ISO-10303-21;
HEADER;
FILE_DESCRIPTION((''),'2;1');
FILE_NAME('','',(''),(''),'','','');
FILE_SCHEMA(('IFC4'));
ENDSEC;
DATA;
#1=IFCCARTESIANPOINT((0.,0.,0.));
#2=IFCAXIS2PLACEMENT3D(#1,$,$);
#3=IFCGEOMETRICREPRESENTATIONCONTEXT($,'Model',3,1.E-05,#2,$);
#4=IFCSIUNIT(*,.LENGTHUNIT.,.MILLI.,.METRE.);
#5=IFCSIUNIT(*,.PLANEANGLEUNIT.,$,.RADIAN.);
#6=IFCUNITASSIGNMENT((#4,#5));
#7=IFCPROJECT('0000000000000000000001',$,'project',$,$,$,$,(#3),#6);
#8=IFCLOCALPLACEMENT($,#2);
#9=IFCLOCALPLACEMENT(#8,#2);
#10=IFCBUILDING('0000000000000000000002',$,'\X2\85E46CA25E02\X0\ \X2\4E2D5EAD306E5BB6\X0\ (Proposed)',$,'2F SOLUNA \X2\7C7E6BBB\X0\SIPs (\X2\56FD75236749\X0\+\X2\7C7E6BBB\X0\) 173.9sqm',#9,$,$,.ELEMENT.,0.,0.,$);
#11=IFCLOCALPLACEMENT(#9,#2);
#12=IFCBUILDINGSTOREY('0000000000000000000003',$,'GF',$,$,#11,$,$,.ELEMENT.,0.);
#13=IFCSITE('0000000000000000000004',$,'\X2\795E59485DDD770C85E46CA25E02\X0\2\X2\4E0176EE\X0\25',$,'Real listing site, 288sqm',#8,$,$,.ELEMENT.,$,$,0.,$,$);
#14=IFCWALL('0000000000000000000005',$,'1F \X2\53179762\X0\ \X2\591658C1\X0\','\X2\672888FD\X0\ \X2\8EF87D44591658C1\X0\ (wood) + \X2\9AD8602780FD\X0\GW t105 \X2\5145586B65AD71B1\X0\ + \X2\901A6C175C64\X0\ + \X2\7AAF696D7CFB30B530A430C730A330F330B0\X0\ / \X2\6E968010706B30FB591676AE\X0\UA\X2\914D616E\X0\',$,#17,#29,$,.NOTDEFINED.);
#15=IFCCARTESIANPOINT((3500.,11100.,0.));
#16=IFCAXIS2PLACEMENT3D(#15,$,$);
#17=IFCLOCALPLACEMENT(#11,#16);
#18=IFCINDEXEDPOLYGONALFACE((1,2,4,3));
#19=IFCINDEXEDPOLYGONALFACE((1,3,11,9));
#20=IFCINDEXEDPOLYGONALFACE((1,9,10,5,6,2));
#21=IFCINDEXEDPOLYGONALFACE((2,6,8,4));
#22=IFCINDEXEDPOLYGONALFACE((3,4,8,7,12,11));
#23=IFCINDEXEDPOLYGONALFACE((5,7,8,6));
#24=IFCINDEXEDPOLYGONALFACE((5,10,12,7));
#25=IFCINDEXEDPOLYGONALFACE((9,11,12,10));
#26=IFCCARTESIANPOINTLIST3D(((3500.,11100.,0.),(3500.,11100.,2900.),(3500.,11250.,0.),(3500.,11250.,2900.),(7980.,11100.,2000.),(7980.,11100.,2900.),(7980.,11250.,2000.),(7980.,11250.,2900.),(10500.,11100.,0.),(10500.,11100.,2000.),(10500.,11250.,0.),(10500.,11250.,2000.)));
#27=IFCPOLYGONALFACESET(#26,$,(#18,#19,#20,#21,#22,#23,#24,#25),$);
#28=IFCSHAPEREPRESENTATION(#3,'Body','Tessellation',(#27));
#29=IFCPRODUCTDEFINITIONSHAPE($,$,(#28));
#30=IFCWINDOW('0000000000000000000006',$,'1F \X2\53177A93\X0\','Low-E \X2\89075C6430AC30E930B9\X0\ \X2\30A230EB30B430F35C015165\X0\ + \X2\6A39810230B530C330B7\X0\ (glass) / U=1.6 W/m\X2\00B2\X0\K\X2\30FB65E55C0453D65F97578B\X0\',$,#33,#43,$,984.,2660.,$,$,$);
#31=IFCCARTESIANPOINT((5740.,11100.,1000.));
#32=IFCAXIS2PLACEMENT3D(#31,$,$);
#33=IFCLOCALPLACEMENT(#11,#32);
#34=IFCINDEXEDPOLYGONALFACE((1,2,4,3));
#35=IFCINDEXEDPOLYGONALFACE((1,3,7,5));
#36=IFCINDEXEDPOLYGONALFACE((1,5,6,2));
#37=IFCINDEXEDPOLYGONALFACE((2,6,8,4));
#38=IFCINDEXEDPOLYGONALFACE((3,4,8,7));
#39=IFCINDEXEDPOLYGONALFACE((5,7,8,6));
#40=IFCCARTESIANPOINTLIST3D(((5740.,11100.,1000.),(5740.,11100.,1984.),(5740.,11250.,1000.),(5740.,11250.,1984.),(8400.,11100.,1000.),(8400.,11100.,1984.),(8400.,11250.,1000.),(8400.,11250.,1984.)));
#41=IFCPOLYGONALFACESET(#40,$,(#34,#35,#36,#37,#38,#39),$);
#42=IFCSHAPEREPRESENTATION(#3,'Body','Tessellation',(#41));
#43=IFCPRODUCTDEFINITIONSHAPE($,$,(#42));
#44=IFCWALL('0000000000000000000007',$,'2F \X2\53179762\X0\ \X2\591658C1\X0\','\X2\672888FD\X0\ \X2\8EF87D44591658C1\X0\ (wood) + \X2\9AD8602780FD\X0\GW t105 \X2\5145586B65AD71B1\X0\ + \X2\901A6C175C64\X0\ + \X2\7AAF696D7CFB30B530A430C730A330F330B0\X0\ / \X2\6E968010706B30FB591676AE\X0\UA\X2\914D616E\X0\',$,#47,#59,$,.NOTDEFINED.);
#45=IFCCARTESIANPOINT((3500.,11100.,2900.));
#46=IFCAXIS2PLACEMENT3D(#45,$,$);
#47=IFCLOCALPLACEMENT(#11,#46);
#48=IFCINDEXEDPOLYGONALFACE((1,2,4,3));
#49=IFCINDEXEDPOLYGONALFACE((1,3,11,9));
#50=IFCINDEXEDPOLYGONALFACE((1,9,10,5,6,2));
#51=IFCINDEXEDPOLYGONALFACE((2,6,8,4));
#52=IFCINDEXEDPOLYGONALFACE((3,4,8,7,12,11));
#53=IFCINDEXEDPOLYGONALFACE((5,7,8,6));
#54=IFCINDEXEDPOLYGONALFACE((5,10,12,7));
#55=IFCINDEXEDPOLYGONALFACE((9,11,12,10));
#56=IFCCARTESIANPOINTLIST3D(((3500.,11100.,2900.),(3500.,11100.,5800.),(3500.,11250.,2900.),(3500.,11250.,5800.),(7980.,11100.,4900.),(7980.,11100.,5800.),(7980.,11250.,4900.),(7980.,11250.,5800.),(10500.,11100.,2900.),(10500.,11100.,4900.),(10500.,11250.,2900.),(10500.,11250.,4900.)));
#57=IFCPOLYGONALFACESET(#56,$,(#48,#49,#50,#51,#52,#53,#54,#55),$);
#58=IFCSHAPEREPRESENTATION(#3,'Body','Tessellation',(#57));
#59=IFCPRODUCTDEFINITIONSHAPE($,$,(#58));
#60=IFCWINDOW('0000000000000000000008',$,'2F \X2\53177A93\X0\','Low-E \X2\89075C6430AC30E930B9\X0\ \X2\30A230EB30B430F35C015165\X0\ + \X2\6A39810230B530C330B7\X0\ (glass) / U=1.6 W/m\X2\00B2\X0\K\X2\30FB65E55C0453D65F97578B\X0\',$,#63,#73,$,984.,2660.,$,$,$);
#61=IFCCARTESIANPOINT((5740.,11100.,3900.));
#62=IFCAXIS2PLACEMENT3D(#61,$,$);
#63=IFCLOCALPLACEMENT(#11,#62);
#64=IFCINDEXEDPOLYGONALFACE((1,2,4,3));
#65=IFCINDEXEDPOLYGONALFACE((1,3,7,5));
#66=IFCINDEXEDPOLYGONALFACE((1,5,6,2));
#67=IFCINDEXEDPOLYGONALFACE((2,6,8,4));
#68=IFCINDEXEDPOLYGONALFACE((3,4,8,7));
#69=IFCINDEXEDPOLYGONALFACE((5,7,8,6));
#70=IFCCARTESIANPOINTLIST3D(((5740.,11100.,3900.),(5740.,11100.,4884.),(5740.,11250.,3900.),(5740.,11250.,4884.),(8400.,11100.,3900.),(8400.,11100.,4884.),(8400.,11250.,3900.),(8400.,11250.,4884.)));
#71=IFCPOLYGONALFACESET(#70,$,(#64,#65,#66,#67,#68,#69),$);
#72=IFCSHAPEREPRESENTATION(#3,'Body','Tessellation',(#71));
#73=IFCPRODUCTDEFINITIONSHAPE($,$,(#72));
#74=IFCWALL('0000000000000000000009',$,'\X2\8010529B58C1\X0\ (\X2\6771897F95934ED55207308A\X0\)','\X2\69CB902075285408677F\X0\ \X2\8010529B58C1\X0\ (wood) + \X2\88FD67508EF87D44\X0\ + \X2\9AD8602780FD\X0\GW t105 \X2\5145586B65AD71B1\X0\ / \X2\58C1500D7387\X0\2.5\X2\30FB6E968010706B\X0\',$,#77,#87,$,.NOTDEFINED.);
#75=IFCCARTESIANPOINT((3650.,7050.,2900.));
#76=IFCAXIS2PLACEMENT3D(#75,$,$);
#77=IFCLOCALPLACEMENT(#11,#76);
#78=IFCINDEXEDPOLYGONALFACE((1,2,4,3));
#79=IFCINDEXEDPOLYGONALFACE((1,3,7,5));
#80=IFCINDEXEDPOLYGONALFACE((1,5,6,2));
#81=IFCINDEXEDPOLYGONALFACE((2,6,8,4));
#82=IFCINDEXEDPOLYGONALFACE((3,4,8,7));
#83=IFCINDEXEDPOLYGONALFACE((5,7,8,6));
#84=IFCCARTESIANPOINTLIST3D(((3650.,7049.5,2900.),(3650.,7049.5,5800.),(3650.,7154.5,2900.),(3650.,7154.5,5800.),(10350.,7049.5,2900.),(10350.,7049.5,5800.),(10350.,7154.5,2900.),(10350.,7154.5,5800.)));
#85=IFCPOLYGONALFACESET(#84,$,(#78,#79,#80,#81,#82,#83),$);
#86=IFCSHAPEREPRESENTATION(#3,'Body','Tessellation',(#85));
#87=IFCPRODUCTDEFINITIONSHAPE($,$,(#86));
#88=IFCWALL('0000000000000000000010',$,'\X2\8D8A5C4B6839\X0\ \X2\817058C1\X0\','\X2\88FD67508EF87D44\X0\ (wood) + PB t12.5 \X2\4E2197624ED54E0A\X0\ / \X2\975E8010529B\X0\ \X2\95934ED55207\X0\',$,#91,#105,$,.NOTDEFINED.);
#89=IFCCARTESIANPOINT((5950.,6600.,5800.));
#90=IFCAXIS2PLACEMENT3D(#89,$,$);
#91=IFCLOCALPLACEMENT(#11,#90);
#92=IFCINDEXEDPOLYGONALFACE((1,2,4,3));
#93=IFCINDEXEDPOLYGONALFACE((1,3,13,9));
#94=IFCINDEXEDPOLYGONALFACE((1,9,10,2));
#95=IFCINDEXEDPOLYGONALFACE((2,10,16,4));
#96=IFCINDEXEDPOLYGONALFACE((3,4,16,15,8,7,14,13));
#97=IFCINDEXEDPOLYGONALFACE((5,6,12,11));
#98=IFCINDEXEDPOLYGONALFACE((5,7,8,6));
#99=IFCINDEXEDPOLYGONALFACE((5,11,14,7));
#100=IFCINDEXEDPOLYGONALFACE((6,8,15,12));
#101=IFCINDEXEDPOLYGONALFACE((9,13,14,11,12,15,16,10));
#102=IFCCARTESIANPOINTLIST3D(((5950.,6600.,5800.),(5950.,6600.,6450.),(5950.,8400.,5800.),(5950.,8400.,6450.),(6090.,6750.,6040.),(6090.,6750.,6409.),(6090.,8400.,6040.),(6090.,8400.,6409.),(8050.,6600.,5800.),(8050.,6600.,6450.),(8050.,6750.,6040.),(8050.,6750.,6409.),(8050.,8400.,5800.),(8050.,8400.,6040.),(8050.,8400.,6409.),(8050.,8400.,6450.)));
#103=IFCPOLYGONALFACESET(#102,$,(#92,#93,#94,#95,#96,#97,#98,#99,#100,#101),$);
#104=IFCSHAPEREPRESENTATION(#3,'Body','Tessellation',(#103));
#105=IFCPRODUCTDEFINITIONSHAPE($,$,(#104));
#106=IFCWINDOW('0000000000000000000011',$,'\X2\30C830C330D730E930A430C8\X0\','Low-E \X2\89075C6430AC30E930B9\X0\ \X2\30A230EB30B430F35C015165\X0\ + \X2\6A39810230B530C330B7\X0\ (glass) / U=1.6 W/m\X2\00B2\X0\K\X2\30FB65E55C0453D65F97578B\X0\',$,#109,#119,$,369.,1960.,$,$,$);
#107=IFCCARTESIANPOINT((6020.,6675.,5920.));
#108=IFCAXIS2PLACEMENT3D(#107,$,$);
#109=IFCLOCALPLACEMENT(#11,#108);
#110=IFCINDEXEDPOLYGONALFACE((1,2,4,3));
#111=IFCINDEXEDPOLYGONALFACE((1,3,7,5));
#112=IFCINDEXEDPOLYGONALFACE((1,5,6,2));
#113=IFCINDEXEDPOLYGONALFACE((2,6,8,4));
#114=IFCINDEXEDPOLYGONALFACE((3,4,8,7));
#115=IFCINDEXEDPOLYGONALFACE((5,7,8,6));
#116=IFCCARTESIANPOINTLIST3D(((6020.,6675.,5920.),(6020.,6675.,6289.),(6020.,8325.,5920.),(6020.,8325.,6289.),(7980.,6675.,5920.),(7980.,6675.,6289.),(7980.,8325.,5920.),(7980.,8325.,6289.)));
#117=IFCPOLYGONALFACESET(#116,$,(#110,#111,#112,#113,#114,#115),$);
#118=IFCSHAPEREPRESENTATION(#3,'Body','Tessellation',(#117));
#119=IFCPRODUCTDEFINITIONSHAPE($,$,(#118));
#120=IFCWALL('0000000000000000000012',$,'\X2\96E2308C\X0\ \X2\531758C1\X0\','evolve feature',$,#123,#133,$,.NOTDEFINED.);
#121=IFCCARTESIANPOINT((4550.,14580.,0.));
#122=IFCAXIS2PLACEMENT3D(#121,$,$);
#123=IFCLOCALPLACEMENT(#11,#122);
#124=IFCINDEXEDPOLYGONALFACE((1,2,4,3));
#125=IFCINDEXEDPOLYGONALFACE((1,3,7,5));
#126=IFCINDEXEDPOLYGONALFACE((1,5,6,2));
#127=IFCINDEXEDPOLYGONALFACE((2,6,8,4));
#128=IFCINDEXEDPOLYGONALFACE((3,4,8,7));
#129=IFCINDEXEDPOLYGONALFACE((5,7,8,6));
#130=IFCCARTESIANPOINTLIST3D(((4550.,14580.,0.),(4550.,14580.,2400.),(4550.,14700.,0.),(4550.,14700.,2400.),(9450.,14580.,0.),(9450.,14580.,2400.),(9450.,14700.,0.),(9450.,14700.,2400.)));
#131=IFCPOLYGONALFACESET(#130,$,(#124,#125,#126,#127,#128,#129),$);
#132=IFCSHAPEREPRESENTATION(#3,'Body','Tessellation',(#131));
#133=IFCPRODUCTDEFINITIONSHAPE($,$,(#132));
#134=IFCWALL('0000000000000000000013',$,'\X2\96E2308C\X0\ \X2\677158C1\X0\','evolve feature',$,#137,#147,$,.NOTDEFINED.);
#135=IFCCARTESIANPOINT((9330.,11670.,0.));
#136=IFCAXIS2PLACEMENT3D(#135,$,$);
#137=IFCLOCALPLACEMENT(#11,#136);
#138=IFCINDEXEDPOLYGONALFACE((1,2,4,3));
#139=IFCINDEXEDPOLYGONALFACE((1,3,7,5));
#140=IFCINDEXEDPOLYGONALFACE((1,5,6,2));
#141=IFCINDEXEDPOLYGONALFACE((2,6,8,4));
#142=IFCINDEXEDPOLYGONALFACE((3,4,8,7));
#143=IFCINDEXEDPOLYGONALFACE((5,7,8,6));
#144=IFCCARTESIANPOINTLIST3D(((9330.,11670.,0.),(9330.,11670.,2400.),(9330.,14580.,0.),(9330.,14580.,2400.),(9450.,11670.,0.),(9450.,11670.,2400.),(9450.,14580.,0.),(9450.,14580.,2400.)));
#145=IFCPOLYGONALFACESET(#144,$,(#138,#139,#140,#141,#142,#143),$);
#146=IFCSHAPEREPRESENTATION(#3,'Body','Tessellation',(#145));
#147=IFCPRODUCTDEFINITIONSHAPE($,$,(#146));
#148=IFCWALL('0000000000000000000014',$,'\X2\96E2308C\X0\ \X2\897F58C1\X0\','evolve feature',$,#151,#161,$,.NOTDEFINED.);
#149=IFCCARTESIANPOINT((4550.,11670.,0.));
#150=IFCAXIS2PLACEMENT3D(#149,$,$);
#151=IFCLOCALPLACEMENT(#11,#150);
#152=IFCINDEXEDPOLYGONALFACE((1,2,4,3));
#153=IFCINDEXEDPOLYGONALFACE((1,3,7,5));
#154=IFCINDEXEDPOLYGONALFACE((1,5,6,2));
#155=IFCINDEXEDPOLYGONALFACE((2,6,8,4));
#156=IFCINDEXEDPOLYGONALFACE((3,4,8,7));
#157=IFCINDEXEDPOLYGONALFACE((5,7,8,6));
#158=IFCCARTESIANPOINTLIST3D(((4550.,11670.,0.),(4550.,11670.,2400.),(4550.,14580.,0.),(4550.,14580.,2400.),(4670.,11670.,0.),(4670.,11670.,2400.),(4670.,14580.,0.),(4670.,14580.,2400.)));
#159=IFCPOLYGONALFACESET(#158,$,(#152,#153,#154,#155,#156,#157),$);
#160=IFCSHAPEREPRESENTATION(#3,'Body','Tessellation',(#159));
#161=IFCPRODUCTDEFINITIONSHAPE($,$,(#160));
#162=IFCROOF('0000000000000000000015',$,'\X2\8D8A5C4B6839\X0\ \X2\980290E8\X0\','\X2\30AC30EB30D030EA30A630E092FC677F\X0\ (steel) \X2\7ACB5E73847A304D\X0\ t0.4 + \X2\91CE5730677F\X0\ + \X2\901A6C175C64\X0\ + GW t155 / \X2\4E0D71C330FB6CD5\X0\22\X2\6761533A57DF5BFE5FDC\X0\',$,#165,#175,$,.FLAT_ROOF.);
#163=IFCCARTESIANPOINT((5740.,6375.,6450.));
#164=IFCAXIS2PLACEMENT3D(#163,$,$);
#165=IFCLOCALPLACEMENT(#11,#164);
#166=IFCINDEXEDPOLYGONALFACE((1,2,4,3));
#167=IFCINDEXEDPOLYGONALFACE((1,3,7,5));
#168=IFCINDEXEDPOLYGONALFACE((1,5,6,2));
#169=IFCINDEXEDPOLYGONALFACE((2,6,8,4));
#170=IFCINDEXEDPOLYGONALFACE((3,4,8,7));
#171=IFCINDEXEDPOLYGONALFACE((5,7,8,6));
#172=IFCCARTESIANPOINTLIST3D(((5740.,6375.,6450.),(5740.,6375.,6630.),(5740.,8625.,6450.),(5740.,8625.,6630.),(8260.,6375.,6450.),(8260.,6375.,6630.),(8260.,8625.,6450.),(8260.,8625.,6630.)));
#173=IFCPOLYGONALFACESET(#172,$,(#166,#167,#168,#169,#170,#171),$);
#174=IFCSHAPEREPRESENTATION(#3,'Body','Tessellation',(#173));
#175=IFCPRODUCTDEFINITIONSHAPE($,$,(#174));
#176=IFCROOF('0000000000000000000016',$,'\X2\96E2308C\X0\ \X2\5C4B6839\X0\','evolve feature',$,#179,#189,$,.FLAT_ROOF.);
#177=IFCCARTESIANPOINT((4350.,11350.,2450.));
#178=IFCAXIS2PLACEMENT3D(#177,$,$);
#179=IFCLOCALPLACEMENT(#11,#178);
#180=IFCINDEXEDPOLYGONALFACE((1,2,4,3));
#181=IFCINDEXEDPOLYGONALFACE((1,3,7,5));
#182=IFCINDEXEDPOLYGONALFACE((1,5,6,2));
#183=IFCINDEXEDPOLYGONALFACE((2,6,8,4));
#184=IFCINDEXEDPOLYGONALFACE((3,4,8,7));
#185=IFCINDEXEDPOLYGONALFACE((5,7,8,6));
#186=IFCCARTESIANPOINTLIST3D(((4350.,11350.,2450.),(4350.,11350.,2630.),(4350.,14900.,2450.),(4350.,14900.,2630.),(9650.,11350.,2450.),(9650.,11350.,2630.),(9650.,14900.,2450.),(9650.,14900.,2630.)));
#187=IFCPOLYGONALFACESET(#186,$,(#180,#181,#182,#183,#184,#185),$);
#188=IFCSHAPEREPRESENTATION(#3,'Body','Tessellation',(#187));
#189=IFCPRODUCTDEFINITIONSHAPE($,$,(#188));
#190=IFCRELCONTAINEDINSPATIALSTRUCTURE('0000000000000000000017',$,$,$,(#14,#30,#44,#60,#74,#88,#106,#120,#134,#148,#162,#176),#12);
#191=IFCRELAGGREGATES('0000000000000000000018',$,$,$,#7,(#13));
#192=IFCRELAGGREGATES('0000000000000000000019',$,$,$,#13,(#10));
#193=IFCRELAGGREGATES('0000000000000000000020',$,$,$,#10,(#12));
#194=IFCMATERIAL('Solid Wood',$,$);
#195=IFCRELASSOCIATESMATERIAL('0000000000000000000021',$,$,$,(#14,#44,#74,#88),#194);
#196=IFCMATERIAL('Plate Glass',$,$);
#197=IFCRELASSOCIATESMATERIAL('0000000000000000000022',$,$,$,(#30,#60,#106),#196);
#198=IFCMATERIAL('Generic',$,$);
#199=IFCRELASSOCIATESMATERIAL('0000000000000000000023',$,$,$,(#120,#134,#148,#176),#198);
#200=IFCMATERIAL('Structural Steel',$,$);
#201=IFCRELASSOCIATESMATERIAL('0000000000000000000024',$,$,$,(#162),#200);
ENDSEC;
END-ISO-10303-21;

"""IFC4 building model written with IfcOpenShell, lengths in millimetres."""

from ifc_helpers import new_model, si_unit, frame, frame_2d, origin, place, context, project, spatial, rectangle, extrude, material, element, fill, save


model = new_model("IFC4")

# Units and contexts
model_context = context("Model", 3, precision=1e-05, world=origin())
ifc_project = project(units=[si_unit("LENGTHUNIT", "METRE", prefix="MILLI"), si_unit("PLANEANGLEUNIT", "RADIAN")], contexts=[model_context])

# Site, building, storey
site_placement = place(None, origin())
site = spatial("IfcSite", under=ifc_project, at=site_placement, Name="神奈川県藤沢市2丁目25", ObjectType="Real listing site, 288sqm", CompositionType="ELEMENT", RefElevation=0.0)
building_placement = place(site_placement, origin())
building = spatial("IfcBuilding", under=site, at=building_placement, Name="藤沢市 中庭の家 (Proposed)", ObjectType="2F SOLUNA 籾殻SIPs (国産杉+籾殻) 173.9sqm", CompositionType="ELEMENT", ElevationOfRefHeight=0.0, ElevationOfTerrain=0.0)
storey_placement = place(building_placement, origin())
storey = spatial("IfcBuildingStorey", under=building, at=storey_placement, Name="GF", CompositionType="ELEMENT", Elevation=0.0)

# Shared definitions
ifc_material_1 = material(Name="Generic")

# Wall, opening, window
ifc_material_2 = material(Name="Solid Wood")
wall_1_placement = place(storey_placement, frame((3500.0, 11100.0, 0.0)))
wall_1 = element("IfcWall", 1, at=wall_1_placement, inside=storey, material=ifc_material_2, Name="1F 北面 外壁", Description="木製 軸組外壁 (wood) + 高性能GW t105 充填断熱 + 通気層 + 窯業系サイディング / 準耐火・外皮UA配慮", PredefinedType="NOTDEFINED", context=model_context, shape_type="SweptSolid", body=[
    extrude(rectangle(XDim=7000.0, YDim=150.0, at=frame_2d((3500.0, 75.0))), frame((3500.0, 11100.0, 0.0)), (0.0, 0.0, 1.0), 2900.0),
])
opening_1_placement = place(storey_placement, frame((5740.0, 11100.0, 1000.0)))
opening_1 = element("IfcOpeningElement", 2, at=opening_1_placement, cuts=wall_1, PredefinedType="NOTDEFINED", context=model_context, shape_type="SweptSolid", body=[
    extrude(rectangle(XDim=2660.0, YDim=150.0, at=frame_2d((1330.0, 75.0))), frame((5740.0, 11100.0, 1000.0)), (0.0, 0.0, 1.0), 984.0),
])
ifc_material_3 = material(Name="Plate Glass")
window_1_placement = place(storey_placement, frame((5740.0, 11100.0, 1000.0)))
window_1 = element("IfcWindow", 3, at=window_1_placement, inside=storey, material=ifc_material_3, Name="1F 北窓", Description="Low-E 複層ガラス アルゴン封入 + 樹脂サッシ (glass) / U=1.6 W/m²K・日射取得型", OverallHeight=984.0, OverallWidth=2660.0, context=model_context, shape_type="SweptSolid", body=[
    extrude(rectangle(XDim=2660.0, YDim=150.0, at=frame_2d((1330.0, 75.0))), frame((5740.0, 11100.0, 1000.0)), (0.0, 0.0, 1.0), 984.0),
])
fill(opening_1, window_1)

# Wall, opening, window
wall_2_placement = place(storey_placement, frame((3500.0, 11100.0, 2900.0)))
wall_2 = element("IfcWall", 4, at=wall_2_placement, inside=storey, material=ifc_material_2, Name="2F 北面 外壁", Description="木製 軸組外壁 (wood) + 高性能GW t105 充填断熱 + 通気層 + 窯業系サイディング / 準耐火・外皮UA配慮", PredefinedType="NOTDEFINED", context=model_context, shape_type="SweptSolid", body=[
    extrude(rectangle(XDim=7000.0, YDim=150.0, at=frame_2d((3500.0, 75.0))), frame((3500.0, 11100.0, 2900.0)), (0.0, 0.0, 1.0), 2900.0),
])
opening_2_placement = place(storey_placement, frame((5740.0, 11100.0, 3900.0)))
opening_2 = element("IfcOpeningElement", 5, at=opening_2_placement, cuts=wall_2, PredefinedType="NOTDEFINED", context=model_context, shape_type="SweptSolid", body=[
    extrude(rectangle(XDim=2660.0, YDim=150.0, at=frame_2d((1330.0, 75.0))), frame((5740.0, 11100.0, 3900.0)), (0.0, 0.0, 1.0), 984.0),
])
window_2_placement = place(storey_placement, frame((5740.0, 11100.0, 3900.0)))
window_2 = element("IfcWindow", 6, at=window_2_placement, inside=storey, material=ifc_material_3, Name="2F 北窓", Description="Low-E 複層ガラス アルゴン封入 + 樹脂サッシ (glass) / U=1.6 W/m²K・日射取得型", OverallHeight=984.0, OverallWidth=2660.0, context=model_context, shape_type="SweptSolid", body=[
    extrude(rectangle(XDim=2660.0, YDim=150.0, at=frame_2d((1330.0, 75.0))), frame((5740.0, 11100.0, 3900.0)), (0.0, 0.0, 1.0), 984.0),
])
fill(opening_2, window_2)

# Wall
wall_3_placement = place(storey_placement, frame((3650.0, 7050.0, 2900.0)))
element("IfcWall", 7, at=wall_3_placement, inside=storey, material=ifc_material_2, Name="耐力壁 (東西間仕切り)", Description="構造用合板 耐力壁 (wood) + 製材軸組 + 高性能GW t105 充填断熱 / 壁倍率2.5・準耐火", PredefinedType="NOTDEFINED", context=model_context, shape_type="SweptSolid", body=[
    extrude(rectangle(XDim=6700.0, YDim=105.0, at=frame_2d((3350.0, 52.0))), frame((3650.0, 7050.0, 2900.0)), (0.0, 0.0, 1.0), 2900.0),
])

# Wall, opening, window
wall_4_placement = place(storey_placement, frame((5950.0, 6600.0, 5800.0)))
wall_4 = element("IfcWall", 8, at=wall_4_placement, inside=storey, material=ifc_material_2, Name="越屋根 腰壁", Description="製材軸組 (wood) + PB t12.5 両面仕上 / 非耐力 間仕切", PredefinedType="NOTDEFINED", context=model_context, shape_type="SweptSolid", body=[
    extrude(rectangle(XDim=2100.0, YDim=1800.0, at=frame_2d((1050.0, 900.0))), frame((5950.0, 6600.0, 5800.0)), (0.0, 0.0, 1.0), 650.0),
])
opening_3_placement = place(storey_placement, frame((6020.0, 6675.0, 5920.0)))
opening_3 = element("IfcOpeningElement", 9, at=opening_3_placement, cuts=wall_4, PredefinedType="NOTDEFINED", context=model_context, shape_type="SweptSolid", body=[
    extrude(rectangle(XDim=1960.0, YDim=1650.0, at=frame_2d((980.0, 825.0))), frame((6020.0, 6675.0, 5920.0)), (0.0, 0.0, 1.0), 369.0),
])
window_3_placement = place(storey_placement, frame((6020.0, 6675.0, 5920.0)))
window_3 = element("IfcWindow", 10, at=window_3_placement, inside=storey, material=ifc_material_3, Name="トップライト", Description="Low-E 複層ガラス アルゴン封入 + 樹脂サッシ (glass) / U=1.6 W/m²K・日射取得型", OverallHeight=369.0, OverallWidth=1960.0, context=model_context, shape_type="SweptSolid", body=[
    extrude(rectangle(XDim=1960.0, YDim=1650.0, at=frame_2d((980.0, 825.0))), frame((6020.0, 6675.0, 5920.0)), (0.0, 0.0, 1.0), 369.0),
])
fill(opening_3, window_3)

# Walls
wall_5_placement = place(storey_placement, frame((4550.0, 14580.0, 0.0)))
element("IfcWall", 11, at=wall_5_placement, inside=storey, material=ifc_material_1, Name="離れ 北壁", Description="evolve feature", PredefinedType="NOTDEFINED", context=model_context, shape_type="SweptSolid", body=[
    extrude(rectangle(XDim=4900.0, YDim=120.0, at=frame_2d((2450.0, 60.0))), frame((4550.0, 14580.0, 0.0)), (0.0, 0.0, 1.0), 2400.0),
])
wall_6_placement = place(storey_placement, frame((9330.0, 11670.0, 0.0)))
element("IfcWall", 12, at=wall_6_placement, inside=storey, material=ifc_material_1, Name="離れ 東壁", Description="evolve feature", PredefinedType="NOTDEFINED", context=model_context, shape_type="SweptSolid", body=[
    extrude(rectangle(XDim=120.0, YDim=2910.0, at=frame_2d((60.0, 1455.0))), frame((9330.0, 11670.0, 0.0)), (0.0, 0.0, 1.0), 2400.0),
])
wall_7_placement = place(storey_placement, frame((4550.0, 11670.0, 0.0)))
element("IfcWall", 13, at=wall_7_placement, inside=storey, material=ifc_material_1, Name="離れ 西壁", Description="evolve feature", PredefinedType="NOTDEFINED", context=model_context, shape_type="SweptSolid", body=[
    extrude(rectangle(XDim=120.0, YDim=2910.0, at=frame_2d((60.0, 1455.0))), frame((4550.0, 11670.0, 0.0)), (0.0, 0.0, 1.0), 2400.0),
])

# Roofs
ifc_material_4 = material(Name="Structural Steel")
roof_1_placement = place(storey_placement, frame((5740.0, 6375.0, 6450.0)))
element("IfcRoof", 14, at=roof_1_placement, inside=storey, material=ifc_material_4, Name="越屋根 頂部", Description="ガルバリウム鋼板 (steel) 立平葺き t0.4 + 野地板 + 通気層 + GW t155 / 不燃・法22条区域対応", PredefinedType="FLAT_ROOF", context=model_context, shape_type="SweptSolid", body=[
    extrude(rectangle(XDim=2520.0, YDim=2250.0, at=frame_2d((1260.0, 1125.0))), frame((5740.0, 6375.0, 6450.0)), (0.0, 0.0, 1.0), 180.0),
])
roof_2_placement = place(storey_placement, frame((4350.0, 11350.0, 2450.0)))
element("IfcRoof", 15, at=roof_2_placement, inside=storey, material=ifc_material_1, Name="離れ 屋根", Description="evolve feature", PredefinedType="FLAT_ROOF", context=model_context, shape_type="SweptSolid", body=[
    extrude(rectangle(XDim=5300.0, YDim=3550.0, at=frame_2d((2650.0, 1775.0))), frame((4350.0, 11350.0, 2450.0)), (0.0, 0.0, 1.0), 180.0),
])

save(model, "model.ifc")
